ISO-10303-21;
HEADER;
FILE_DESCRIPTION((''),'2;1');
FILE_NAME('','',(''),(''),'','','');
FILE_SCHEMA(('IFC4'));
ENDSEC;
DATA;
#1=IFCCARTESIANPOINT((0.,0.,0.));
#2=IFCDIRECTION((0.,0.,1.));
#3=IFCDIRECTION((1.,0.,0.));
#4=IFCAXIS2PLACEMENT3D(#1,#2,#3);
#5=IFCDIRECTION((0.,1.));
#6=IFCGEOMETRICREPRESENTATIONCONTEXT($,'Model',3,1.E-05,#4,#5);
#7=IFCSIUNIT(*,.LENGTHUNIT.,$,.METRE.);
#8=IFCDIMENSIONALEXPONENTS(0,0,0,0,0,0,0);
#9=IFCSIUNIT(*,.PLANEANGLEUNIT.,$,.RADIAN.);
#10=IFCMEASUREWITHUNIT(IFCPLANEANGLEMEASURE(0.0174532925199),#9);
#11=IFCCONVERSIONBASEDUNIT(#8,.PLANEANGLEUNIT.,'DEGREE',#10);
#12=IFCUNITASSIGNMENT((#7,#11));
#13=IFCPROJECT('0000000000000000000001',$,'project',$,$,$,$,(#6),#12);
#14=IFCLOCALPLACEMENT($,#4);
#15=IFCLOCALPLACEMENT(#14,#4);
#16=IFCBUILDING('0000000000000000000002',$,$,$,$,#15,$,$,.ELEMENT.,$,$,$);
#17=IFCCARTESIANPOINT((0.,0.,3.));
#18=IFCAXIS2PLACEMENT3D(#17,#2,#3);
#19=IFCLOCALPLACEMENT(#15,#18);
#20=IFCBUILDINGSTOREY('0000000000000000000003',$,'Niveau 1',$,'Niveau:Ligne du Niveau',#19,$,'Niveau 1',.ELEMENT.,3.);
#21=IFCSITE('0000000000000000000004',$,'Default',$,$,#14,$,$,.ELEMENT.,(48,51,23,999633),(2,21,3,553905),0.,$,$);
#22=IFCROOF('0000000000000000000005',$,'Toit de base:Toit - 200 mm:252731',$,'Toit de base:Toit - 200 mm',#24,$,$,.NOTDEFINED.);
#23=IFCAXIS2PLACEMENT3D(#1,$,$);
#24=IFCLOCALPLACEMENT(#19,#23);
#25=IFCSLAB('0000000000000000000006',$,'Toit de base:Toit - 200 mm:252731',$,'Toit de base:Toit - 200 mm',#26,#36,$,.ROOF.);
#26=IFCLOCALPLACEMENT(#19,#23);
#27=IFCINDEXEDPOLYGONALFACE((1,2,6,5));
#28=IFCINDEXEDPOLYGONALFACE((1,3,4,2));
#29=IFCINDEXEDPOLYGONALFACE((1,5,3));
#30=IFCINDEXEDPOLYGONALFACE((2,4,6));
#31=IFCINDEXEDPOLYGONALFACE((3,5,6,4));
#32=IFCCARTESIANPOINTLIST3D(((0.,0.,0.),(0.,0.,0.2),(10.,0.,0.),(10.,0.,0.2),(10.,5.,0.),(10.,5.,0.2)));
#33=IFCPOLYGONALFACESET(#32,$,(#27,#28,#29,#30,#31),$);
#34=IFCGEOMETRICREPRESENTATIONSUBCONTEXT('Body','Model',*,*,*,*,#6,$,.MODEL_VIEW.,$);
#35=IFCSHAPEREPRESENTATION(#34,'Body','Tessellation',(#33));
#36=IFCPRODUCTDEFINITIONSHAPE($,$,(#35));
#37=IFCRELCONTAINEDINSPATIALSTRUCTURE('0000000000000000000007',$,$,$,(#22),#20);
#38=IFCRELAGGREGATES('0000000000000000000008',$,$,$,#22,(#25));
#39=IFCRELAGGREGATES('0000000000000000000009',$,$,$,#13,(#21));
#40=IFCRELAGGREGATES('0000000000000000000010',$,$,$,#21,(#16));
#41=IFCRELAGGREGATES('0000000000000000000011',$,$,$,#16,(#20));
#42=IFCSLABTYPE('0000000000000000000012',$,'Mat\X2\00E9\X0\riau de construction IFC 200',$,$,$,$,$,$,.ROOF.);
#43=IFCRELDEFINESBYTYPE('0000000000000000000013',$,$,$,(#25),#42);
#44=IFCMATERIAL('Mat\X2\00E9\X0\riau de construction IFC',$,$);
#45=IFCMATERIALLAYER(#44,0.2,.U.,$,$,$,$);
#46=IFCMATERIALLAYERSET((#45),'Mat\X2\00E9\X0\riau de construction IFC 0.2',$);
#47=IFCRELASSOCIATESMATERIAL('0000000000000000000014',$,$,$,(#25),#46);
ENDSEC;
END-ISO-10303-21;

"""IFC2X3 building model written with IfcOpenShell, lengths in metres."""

from ifc_helpers import new_model, entity, si_unit, converted_unit, direction, frame, origin_with_axes, place, context, subcontext, project, spatial, polyline, outline, extrude, material, layer, layer_set, layer_usage, type_object, element, aggregate, save


model = new_model("IFC2X3")

# Units and contexts
model_context = context("Model", 3, precision=1e-05, world=origin_with_axes(), true_north=direction((0.0, 1.0)))
body_context = subcontext(model_context, "Body", "Model", "MODEL_VIEW")
ifc_project = project(units=[si_unit("LENGTHUNIT", "METRE"), converted_unit("PLANEANGLEUNIT", "DEGREE", entity("IfcPlaneAngleMeasure", 0.0174532925199), si_unit("PLANEANGLEUNIT", "RADIAN"), dimensions=[0, 0, 0, 0, 0, 0, 0])], contexts=[model_context])

# Site, building, storey
site_placement = place(None, origin_with_axes())
site = spatial("IfcSite", under=ifc_project, at=site_placement, Name="Default", CompositionType="ELEMENT", RefLatitude=(48, 51, 23, 999633), RefLongitude=(2, 21, 3, 553905), RefElevation=0.0)
building_placement = place(site_placement, origin_with_axes())
building = spatial("IfcBuilding", under=site, at=building_placement, CompositionType="ELEMENT")
storey_placement = place(building_placement, frame((0.0, 0.0, 3.0), z_axis=(0.0, 0.0, 1.0), x_axis=(1.0, 0.0, 0.0)))
storey = spatial("IfcBuildingStorey", under=building, at=storey_placement, Name="Niveau 1", ObjectType="Niveau:Ligne du Niveau", LongName="Niveau 1", CompositionType="ELEMENT", Elevation=3.0)

# Roof, slab
roof_placement = place(storey_placement, frame((0.0, 0.0, -3.0), z_axis=(0.0, 0.0, 1.0), x_axis=(1.0, 0.0, 0.0)))
roof = element("IfcRoof", 1, at=roof_placement, inside=storey, Name="Toit de base:Toit - 200 mm:252731", ObjectType="Toit de base:Toit - 200 mm", ShapeType="NOTDEFINED")
ifc_material = material(Name="Matériau de construction IFC")
ifc_layer = layer(ifc_material, 0.2, ventilated="UNKNOWN")
ifc_layer_set = layer_set([ifc_layer], Name="Matériau de construction IFC 0.2")
ifc_layer_usage = layer_usage(ifc_layer_set, "AXIS3", "NEGATIVE", 0.2)
slab_type = type_object("IfcSlabType", Name="Matériau de construction IFC 200", PredefinedType="ROOF")
slab_placement = place(roof_placement, frame((10.0, 5.0, 3.0), z_axis=(0.0, 0.0, 1.0), x_axis=(-0.894427, -0.447214, 0.0)))
slab = element("IfcSlab", 2, at=slab_placement, type_object=slab_type, material=ifc_layer_usage, Name="Toit de base:Toit - 200 mm:252731", ObjectType="Toit de base:Toit - 200 mm", PredefinedType="ROOF", context=body_context, shape_type="SweptSolid", body=[
    extrude(outline(polyline([(0.0, 0.0), (11.1803, 0.0), (2.2361, 4.4721), (0.0, 0.0)])), origin_with_axes(), (0.0, 0.0, 1.0), 0.2),
])
aggregate(roof, [slab])

save(model, "model.ifc")
